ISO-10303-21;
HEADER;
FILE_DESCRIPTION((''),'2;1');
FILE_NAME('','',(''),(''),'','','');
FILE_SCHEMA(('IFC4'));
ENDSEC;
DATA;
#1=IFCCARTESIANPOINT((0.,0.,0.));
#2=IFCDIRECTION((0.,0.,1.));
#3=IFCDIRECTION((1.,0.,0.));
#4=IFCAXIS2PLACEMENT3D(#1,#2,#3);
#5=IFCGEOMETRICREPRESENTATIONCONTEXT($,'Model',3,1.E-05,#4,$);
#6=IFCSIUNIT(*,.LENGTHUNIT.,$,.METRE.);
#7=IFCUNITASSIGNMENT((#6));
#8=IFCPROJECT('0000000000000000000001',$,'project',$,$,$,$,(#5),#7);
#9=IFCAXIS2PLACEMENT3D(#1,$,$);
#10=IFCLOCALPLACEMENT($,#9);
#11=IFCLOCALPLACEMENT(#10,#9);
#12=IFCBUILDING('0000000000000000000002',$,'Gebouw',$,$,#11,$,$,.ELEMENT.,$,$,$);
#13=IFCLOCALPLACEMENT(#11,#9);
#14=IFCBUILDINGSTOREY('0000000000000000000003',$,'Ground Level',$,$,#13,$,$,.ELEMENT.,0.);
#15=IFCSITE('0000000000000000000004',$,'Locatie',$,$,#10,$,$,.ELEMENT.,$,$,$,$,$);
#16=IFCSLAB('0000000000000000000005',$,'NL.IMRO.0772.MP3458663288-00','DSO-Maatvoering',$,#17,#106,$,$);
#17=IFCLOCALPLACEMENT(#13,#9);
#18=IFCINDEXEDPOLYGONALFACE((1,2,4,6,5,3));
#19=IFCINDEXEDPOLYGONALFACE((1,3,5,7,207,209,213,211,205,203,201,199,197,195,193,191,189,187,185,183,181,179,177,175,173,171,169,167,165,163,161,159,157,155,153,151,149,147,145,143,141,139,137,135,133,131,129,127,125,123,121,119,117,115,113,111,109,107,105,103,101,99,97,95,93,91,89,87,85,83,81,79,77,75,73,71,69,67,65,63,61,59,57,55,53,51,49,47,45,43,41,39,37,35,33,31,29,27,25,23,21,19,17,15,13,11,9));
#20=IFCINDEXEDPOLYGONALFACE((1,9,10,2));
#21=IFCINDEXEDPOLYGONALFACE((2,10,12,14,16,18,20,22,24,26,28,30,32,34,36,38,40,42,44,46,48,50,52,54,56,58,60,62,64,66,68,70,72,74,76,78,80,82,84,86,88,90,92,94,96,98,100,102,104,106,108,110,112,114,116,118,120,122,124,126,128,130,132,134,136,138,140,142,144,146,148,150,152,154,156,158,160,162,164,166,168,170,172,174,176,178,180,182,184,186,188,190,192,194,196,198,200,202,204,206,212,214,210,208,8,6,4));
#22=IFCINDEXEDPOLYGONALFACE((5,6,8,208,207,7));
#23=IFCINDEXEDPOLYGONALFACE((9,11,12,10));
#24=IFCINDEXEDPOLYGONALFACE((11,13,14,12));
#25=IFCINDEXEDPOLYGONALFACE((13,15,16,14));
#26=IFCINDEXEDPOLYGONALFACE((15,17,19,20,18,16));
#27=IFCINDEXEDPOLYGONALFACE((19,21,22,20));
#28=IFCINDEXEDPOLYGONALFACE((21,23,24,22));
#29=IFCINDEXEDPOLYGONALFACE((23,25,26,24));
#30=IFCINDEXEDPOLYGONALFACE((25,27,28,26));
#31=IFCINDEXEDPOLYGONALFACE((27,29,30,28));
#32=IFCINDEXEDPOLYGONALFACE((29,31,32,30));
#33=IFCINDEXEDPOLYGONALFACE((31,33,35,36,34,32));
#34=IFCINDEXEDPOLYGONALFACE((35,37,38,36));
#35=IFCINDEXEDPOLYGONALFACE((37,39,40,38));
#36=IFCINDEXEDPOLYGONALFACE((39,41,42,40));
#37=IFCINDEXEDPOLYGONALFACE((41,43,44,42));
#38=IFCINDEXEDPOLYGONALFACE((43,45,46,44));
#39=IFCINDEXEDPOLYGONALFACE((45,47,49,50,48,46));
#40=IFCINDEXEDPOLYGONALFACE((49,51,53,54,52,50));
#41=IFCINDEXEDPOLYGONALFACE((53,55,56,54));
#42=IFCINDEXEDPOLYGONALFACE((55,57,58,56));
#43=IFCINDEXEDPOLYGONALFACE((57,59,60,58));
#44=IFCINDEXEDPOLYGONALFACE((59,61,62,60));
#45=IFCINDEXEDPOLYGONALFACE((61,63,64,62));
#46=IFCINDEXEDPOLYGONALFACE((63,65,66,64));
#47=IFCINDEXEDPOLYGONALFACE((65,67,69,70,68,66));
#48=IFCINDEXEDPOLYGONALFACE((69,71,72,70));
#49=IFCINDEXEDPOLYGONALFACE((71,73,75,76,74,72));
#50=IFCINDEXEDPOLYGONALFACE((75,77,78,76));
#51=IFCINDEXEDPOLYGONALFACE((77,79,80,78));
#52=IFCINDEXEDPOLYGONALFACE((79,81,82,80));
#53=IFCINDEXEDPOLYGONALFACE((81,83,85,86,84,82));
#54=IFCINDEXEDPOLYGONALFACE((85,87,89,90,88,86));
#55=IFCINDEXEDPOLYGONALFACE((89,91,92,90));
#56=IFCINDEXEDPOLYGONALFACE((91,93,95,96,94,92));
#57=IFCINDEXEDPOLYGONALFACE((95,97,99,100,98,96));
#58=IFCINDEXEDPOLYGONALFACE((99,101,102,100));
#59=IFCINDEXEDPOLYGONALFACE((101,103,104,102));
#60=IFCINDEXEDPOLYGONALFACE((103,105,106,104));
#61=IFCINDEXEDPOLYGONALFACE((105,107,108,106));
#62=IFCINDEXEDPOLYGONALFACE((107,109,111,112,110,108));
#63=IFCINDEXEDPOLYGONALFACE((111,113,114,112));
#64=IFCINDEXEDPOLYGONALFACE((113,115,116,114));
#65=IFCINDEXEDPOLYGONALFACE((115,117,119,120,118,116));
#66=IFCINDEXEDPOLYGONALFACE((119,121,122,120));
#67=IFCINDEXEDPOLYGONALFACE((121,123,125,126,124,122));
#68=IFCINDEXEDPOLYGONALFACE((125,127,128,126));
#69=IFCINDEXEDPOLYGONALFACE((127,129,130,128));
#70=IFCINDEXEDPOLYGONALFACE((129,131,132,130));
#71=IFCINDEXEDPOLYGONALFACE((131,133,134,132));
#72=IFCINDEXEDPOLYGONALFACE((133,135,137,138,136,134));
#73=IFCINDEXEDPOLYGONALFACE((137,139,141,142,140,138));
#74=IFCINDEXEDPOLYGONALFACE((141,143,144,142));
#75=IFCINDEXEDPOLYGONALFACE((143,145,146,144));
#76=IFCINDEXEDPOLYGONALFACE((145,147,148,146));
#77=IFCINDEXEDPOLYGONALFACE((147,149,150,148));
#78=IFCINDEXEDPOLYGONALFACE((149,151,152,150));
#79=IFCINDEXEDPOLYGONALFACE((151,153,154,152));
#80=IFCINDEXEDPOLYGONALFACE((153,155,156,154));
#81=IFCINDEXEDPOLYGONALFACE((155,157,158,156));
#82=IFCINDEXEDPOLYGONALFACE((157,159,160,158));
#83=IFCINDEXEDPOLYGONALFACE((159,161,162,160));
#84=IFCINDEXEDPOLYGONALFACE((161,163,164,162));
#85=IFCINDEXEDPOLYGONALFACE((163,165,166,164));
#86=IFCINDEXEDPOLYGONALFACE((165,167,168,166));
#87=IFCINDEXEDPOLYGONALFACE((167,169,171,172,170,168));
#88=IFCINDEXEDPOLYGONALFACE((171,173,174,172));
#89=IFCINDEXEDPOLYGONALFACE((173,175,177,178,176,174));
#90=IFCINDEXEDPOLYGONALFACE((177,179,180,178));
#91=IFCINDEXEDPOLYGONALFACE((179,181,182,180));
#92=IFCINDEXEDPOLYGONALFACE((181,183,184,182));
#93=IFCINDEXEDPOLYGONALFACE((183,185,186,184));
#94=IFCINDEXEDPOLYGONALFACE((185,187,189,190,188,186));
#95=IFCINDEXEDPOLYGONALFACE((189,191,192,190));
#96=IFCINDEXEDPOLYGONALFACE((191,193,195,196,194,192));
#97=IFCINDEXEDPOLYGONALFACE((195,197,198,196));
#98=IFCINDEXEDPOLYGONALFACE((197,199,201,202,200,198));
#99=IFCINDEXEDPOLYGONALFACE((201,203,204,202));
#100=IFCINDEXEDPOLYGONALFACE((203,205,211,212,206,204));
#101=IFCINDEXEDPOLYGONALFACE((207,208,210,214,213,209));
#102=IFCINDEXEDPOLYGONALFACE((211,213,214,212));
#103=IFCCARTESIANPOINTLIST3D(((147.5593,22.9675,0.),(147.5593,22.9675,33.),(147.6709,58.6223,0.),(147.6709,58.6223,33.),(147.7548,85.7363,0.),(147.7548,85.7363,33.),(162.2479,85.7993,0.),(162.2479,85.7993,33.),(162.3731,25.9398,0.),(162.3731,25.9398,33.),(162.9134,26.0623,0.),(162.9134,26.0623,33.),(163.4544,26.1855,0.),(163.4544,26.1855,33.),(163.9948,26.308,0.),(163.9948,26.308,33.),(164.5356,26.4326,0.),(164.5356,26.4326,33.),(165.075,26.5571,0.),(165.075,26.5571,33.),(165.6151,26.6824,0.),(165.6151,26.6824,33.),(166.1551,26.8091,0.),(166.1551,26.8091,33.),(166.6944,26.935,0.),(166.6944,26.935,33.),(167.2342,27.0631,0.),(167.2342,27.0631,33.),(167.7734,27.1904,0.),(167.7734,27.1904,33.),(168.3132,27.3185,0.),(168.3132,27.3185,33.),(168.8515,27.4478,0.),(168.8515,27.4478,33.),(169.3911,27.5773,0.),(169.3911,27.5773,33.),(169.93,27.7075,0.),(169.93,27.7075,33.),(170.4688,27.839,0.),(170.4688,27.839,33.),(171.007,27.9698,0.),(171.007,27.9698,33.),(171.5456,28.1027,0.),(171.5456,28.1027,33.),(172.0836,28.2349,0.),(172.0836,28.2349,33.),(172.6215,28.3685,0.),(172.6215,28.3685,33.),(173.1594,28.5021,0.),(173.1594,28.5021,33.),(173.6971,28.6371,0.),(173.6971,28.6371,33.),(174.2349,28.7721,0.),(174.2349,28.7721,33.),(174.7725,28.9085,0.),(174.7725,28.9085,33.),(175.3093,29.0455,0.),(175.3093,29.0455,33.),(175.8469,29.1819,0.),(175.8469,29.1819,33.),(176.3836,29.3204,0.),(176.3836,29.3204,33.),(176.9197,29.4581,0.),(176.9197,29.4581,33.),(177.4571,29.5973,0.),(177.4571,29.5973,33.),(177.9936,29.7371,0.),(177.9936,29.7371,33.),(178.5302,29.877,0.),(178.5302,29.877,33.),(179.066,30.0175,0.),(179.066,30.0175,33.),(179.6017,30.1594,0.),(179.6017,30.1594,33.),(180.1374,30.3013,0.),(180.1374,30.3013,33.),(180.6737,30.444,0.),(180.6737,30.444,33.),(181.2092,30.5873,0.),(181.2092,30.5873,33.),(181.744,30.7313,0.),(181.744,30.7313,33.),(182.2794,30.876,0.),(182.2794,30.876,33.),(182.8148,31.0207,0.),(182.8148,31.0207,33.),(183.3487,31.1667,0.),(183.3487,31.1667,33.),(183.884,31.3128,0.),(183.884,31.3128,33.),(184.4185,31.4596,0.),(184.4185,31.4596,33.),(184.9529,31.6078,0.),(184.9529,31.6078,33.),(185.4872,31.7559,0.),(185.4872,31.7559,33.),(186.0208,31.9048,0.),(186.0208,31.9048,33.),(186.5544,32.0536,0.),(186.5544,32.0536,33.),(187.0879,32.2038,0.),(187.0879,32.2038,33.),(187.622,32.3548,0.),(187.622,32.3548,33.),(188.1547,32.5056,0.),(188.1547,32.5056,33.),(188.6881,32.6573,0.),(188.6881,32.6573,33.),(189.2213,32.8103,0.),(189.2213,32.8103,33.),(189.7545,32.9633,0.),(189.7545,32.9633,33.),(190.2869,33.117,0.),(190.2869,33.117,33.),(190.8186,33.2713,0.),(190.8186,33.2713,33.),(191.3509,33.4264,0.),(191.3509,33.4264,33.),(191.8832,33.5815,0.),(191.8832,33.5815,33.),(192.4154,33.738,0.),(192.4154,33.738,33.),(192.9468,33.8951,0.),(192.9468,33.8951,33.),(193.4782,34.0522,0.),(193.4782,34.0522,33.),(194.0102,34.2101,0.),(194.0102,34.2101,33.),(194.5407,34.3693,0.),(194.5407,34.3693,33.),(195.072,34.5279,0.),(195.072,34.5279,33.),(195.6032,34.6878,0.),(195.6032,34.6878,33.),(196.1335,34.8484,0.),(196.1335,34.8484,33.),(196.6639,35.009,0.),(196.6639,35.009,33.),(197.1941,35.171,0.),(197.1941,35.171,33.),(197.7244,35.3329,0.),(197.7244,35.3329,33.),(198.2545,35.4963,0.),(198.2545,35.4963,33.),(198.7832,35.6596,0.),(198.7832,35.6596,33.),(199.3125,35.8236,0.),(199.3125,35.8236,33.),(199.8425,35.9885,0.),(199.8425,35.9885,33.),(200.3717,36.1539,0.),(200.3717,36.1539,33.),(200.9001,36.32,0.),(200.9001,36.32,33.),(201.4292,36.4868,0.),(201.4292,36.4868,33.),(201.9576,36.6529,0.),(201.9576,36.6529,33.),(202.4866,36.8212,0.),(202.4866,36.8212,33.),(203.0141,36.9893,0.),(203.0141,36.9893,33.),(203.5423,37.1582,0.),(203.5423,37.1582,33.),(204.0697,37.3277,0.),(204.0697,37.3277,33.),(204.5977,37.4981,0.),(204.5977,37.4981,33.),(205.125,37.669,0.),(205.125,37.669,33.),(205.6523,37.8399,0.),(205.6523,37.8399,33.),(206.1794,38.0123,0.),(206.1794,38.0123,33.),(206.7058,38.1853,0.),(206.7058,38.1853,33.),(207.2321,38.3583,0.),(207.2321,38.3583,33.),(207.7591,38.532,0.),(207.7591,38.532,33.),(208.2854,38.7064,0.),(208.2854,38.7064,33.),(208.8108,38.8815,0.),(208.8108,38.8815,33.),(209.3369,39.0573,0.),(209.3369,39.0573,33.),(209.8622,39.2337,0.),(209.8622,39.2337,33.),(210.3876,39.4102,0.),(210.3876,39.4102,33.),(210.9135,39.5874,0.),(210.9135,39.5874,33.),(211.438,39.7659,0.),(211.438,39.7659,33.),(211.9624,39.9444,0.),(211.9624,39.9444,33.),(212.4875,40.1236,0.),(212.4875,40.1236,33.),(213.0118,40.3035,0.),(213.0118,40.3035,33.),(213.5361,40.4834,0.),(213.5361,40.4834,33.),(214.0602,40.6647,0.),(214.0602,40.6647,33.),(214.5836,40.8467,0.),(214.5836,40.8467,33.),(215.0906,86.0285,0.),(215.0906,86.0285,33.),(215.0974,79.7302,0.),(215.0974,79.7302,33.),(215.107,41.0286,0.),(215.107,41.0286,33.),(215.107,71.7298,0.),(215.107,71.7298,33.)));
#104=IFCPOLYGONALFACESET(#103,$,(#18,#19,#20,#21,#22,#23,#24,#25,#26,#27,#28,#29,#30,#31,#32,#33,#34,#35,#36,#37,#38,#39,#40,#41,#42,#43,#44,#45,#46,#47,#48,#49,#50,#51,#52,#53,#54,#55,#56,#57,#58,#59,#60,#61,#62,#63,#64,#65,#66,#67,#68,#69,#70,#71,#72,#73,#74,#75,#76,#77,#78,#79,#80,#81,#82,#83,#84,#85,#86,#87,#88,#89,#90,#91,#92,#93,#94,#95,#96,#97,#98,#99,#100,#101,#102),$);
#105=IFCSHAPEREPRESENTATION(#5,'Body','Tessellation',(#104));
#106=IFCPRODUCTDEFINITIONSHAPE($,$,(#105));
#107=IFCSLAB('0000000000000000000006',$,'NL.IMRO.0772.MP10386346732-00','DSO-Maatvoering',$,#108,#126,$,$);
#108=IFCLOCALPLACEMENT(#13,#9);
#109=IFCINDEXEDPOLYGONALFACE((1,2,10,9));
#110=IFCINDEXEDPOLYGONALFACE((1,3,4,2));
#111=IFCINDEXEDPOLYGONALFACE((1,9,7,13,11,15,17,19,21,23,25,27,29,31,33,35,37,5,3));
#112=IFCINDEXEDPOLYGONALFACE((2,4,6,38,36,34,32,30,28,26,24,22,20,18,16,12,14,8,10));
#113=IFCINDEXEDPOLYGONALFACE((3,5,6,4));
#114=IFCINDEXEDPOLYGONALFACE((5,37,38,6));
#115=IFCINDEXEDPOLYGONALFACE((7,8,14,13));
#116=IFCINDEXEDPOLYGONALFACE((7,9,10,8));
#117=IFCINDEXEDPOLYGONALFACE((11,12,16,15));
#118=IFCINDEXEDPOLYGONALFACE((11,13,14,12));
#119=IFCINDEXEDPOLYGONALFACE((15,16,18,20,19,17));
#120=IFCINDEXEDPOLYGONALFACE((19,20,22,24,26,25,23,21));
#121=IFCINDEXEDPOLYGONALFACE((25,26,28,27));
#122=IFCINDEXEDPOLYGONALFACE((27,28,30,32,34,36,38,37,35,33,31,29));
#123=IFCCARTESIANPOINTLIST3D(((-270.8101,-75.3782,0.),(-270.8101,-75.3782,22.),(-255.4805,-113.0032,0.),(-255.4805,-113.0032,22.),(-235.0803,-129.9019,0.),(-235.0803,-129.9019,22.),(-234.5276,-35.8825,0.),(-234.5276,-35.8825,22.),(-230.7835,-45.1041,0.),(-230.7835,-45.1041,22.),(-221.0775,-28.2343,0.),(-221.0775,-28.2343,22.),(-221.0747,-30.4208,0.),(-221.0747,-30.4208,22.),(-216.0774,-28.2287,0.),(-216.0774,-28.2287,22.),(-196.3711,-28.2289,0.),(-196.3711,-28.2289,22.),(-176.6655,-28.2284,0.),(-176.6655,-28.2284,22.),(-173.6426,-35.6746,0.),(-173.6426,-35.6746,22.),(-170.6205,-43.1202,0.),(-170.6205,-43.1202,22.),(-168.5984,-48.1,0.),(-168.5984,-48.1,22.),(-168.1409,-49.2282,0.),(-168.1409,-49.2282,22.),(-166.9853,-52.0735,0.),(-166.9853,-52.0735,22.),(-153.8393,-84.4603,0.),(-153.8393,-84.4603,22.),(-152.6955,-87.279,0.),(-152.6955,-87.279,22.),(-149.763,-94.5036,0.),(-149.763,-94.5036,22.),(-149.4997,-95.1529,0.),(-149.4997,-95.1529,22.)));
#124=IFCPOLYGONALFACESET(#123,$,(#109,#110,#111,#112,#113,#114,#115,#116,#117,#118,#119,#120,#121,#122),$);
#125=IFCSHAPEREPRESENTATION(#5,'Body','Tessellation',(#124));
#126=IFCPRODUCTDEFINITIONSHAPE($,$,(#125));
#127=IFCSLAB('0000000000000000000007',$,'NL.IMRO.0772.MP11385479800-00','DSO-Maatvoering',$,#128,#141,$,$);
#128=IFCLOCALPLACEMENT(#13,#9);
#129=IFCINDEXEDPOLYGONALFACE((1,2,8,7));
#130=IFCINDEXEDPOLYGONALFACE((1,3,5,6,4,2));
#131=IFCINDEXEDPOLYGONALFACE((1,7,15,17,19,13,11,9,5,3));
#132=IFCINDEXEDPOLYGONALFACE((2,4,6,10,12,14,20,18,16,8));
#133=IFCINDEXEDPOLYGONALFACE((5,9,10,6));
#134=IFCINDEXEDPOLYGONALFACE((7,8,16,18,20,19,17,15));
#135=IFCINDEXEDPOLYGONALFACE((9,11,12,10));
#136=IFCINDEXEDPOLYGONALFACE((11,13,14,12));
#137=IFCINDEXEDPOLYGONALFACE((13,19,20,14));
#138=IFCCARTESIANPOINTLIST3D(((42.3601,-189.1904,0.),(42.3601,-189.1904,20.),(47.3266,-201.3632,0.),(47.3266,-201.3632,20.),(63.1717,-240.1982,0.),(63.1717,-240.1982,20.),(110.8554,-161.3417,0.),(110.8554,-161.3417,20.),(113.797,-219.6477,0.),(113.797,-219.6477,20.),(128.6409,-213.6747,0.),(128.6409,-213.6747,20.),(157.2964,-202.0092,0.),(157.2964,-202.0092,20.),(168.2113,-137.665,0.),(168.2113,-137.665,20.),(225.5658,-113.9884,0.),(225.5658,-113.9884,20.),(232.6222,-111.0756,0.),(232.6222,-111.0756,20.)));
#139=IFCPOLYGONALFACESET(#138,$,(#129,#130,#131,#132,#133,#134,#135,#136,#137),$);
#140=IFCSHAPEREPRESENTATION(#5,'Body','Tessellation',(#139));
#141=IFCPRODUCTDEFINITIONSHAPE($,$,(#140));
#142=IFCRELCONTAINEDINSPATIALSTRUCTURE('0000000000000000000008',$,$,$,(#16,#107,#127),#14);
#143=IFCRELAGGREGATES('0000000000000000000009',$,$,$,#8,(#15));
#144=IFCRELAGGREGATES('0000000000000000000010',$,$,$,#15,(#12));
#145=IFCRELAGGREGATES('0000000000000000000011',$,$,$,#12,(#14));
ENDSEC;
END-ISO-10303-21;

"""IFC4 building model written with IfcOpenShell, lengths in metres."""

from ifc_helpers import new_model, si_unit, origin, origin_with_axes, place, context, project, spatial, polyline, outline, extrude, element, save


model = new_model("IFC4")

# Units and contexts
model_context = context("Model", 3, precision=1e-05, world=origin_with_axes())
ifc_project = project(units=[si_unit("LENGTHUNIT", "METRE")], contexts=[model_context])

# Site, building, storey
site_placement = place(None, origin())
site = spatial("IfcSite", under=ifc_project, at=site_placement, Name="Locatie", CompositionType="ELEMENT")
building_placement = place(site_placement, origin())
building = spatial("IfcBuilding", under=site, at=building_placement, Name="Gebouw", CompositionType="ELEMENT")
storey_placement = place(building_placement, origin())
storey = spatial("IfcBuildingStorey", under=building, at=storey_placement, Name="Ground Level", CompositionType="ELEMENT", Elevation=0.0)

# Slabs
slab_1_placement = place(storey_placement, origin())
element("IfcSlab", 1, at=slab_1_placement, inside=storey, Name="NL.IMRO.0772.MP3458663288-00", Description="DSO-Maatvoering", context=model_context, shape_type="SweptSolid", body=[
    extrude(outline(polyline([(147.5593, 22.9675), (147.6709, 58.6223), (147.7548, 85.7363), (162.2479, 85.7993), (215.0906, 86.0285), (215.0974, 79.7302), (215.107, 71.7298), (215.107, 41.0286), (214.5836, 40.8467), (214.0602, 40.6647), (213.5361, 40.4834), (213.0118, 40.3035), (212.4875, 40.1236), (211.9624, 39.9444), (211.438, 39.7659), (210.9135, 39.5874), (210.3876, 39.4102), (209.8622, 39.2337), (209.3369, 39.0573), (208.8108, 38.8815), (208.2854, 38.7064), (207.7591, 38.532), (207.2321, 38.3583), (206.7058, 38.1853), (206.1794, 38.0123), (205.6523, 37.8399), (205.125, 37.669), (204.5977, 37.4981), (204.0697, 37.3277), (203.5423, 37.1582), (203.0141, 36.9893), (202.4866, 36.8212), (201.9576, 36.6529), (201.4292, 36.4868), (200.9001, 36.32), (200.3717, 36.1539), (199.8425, 35.9885), (199.3125, 35.8236), (198.7832, 35.6596), (198.2545, 35.4963), (197.7244, 35.3329), (197.1941, 35.171), (196.6639, 35.009), (196.1335, 34.8484), (195.6032, 34.6878), (195.072, 34.5279), (194.5407, 34.3693), (194.0102, 34.2101), (193.4782, 34.0522), (192.9468, 33.8951), (192.4154, 33.738), (191.8832, 33.5815), (191.3509, 33.4264), (190.8186, 33.2713), (190.2869, 33.117), (189.7545, 32.9633), (189.2213, 32.8103), (188.6881, 32.6573), (188.1547, 32.5056), (187.622, 32.3548), (187.0879, 32.2038), (186.5544, 32.0536), (186.0208, 31.9048), (185.4872, 31.7559), (184.9529, 31.6078), (184.4185, 31.4596), (183.884, 31.3128), (183.3487, 31.1667), (182.8148, 31.0207), (182.2794, 30.876), (181.744, 30.7313), (181.2092, 30.5873), (180.6737, 30.444), (180.1374, 30.3013), (179.6017, 30.1594), (179.066, 30.0175), (178.5302, 29.877), (177.9936, 29.7371), (177.4571, 29.5973), (176.9197, 29.4581), (176.3836, 29.3204), (175.8469, 29.1819), (175.3093, 29.0455), (174.7725, 28.9085), (174.2349, 28.7721), (173.6971, 28.6371), (173.1594, 28.5021), (172.6215, 28.3685), (172.0836, 28.2349), (171.5456, 28.1027), (171.007, 27.9698), (170.4688, 27.839), (169.93, 27.7075), (169.3911, 27.5773), (168.8515, 27.4478), (168.3132, 27.3185), (167.7734, 27.1904), (167.2342, 27.0631), (166.6944, 26.935), (166.1551, 26.8091), (165.6151, 26.6824), (165.075, 26.5571), (164.5356, 26.4326), (163.9948, 26.308), (163.4544, 26.1855), (162.9134, 26.0623), (162.3731, 25.9398), (147.5593, 22.9675)])), origin_with_axes(), (0.0, 0.0, 1.0), 33.0),
])
slab_2_placement = place(storey_placement, origin())
element("IfcSlab", 2, at=slab_2_placement, inside=storey, Name="NL.IMRO.0772.MP10386346732-00", Description="DSO-Maatvoering", context=model_context, shape_type="SweptSolid", body=[
    extrude(outline(polyline([(-270.8101, -75.3782), (-230.7835, -45.1041), (-234.5276, -35.8825), (-221.0747, -30.4208), (-221.0775, -28.2343), (-216.0774, -28.2287), (-196.3711, -28.2289), (-176.6655, -28.2284), (-173.6426, -35.6746), (-170.6205, -43.1202), (-168.5984, -48.1), (-168.1409, -49.2282), (-166.9853, -52.0735), (-153.8393, -84.4603), (-152.6955, -87.279), (-149.763, -94.5036), (-149.4997, -95.1529), (-235.0803, -129.9019), (-255.4805, -113.0032), (-270.8101, -75.3782)])), origin_with_axes(), (0.0, 0.0, 1.0), 22.0),
])
slab_3_placement = place(storey_placement, origin())
element("IfcSlab", 3, at=slab_3_placement, inside=storey, Name="NL.IMRO.0772.MP11385479800-00", Description="DSO-Maatvoering", context=model_context, shape_type="SweptSolid", body=[
    extrude(outline(polyline([(128.6409, -213.6747), (113.797, -219.6477), (63.1717, -240.1982), (47.3266, -201.3632), (42.3601, -189.1904), (110.8554, -161.3417), (168.2113, -137.665), (225.5658, -113.9884), (232.6222, -111.0756), (157.2964, -202.0092), (128.6409, -213.6747)])), origin_with_axes(), (0.0, 0.0, 1.0), 20.0),
])

save(model, "model.ifc")
